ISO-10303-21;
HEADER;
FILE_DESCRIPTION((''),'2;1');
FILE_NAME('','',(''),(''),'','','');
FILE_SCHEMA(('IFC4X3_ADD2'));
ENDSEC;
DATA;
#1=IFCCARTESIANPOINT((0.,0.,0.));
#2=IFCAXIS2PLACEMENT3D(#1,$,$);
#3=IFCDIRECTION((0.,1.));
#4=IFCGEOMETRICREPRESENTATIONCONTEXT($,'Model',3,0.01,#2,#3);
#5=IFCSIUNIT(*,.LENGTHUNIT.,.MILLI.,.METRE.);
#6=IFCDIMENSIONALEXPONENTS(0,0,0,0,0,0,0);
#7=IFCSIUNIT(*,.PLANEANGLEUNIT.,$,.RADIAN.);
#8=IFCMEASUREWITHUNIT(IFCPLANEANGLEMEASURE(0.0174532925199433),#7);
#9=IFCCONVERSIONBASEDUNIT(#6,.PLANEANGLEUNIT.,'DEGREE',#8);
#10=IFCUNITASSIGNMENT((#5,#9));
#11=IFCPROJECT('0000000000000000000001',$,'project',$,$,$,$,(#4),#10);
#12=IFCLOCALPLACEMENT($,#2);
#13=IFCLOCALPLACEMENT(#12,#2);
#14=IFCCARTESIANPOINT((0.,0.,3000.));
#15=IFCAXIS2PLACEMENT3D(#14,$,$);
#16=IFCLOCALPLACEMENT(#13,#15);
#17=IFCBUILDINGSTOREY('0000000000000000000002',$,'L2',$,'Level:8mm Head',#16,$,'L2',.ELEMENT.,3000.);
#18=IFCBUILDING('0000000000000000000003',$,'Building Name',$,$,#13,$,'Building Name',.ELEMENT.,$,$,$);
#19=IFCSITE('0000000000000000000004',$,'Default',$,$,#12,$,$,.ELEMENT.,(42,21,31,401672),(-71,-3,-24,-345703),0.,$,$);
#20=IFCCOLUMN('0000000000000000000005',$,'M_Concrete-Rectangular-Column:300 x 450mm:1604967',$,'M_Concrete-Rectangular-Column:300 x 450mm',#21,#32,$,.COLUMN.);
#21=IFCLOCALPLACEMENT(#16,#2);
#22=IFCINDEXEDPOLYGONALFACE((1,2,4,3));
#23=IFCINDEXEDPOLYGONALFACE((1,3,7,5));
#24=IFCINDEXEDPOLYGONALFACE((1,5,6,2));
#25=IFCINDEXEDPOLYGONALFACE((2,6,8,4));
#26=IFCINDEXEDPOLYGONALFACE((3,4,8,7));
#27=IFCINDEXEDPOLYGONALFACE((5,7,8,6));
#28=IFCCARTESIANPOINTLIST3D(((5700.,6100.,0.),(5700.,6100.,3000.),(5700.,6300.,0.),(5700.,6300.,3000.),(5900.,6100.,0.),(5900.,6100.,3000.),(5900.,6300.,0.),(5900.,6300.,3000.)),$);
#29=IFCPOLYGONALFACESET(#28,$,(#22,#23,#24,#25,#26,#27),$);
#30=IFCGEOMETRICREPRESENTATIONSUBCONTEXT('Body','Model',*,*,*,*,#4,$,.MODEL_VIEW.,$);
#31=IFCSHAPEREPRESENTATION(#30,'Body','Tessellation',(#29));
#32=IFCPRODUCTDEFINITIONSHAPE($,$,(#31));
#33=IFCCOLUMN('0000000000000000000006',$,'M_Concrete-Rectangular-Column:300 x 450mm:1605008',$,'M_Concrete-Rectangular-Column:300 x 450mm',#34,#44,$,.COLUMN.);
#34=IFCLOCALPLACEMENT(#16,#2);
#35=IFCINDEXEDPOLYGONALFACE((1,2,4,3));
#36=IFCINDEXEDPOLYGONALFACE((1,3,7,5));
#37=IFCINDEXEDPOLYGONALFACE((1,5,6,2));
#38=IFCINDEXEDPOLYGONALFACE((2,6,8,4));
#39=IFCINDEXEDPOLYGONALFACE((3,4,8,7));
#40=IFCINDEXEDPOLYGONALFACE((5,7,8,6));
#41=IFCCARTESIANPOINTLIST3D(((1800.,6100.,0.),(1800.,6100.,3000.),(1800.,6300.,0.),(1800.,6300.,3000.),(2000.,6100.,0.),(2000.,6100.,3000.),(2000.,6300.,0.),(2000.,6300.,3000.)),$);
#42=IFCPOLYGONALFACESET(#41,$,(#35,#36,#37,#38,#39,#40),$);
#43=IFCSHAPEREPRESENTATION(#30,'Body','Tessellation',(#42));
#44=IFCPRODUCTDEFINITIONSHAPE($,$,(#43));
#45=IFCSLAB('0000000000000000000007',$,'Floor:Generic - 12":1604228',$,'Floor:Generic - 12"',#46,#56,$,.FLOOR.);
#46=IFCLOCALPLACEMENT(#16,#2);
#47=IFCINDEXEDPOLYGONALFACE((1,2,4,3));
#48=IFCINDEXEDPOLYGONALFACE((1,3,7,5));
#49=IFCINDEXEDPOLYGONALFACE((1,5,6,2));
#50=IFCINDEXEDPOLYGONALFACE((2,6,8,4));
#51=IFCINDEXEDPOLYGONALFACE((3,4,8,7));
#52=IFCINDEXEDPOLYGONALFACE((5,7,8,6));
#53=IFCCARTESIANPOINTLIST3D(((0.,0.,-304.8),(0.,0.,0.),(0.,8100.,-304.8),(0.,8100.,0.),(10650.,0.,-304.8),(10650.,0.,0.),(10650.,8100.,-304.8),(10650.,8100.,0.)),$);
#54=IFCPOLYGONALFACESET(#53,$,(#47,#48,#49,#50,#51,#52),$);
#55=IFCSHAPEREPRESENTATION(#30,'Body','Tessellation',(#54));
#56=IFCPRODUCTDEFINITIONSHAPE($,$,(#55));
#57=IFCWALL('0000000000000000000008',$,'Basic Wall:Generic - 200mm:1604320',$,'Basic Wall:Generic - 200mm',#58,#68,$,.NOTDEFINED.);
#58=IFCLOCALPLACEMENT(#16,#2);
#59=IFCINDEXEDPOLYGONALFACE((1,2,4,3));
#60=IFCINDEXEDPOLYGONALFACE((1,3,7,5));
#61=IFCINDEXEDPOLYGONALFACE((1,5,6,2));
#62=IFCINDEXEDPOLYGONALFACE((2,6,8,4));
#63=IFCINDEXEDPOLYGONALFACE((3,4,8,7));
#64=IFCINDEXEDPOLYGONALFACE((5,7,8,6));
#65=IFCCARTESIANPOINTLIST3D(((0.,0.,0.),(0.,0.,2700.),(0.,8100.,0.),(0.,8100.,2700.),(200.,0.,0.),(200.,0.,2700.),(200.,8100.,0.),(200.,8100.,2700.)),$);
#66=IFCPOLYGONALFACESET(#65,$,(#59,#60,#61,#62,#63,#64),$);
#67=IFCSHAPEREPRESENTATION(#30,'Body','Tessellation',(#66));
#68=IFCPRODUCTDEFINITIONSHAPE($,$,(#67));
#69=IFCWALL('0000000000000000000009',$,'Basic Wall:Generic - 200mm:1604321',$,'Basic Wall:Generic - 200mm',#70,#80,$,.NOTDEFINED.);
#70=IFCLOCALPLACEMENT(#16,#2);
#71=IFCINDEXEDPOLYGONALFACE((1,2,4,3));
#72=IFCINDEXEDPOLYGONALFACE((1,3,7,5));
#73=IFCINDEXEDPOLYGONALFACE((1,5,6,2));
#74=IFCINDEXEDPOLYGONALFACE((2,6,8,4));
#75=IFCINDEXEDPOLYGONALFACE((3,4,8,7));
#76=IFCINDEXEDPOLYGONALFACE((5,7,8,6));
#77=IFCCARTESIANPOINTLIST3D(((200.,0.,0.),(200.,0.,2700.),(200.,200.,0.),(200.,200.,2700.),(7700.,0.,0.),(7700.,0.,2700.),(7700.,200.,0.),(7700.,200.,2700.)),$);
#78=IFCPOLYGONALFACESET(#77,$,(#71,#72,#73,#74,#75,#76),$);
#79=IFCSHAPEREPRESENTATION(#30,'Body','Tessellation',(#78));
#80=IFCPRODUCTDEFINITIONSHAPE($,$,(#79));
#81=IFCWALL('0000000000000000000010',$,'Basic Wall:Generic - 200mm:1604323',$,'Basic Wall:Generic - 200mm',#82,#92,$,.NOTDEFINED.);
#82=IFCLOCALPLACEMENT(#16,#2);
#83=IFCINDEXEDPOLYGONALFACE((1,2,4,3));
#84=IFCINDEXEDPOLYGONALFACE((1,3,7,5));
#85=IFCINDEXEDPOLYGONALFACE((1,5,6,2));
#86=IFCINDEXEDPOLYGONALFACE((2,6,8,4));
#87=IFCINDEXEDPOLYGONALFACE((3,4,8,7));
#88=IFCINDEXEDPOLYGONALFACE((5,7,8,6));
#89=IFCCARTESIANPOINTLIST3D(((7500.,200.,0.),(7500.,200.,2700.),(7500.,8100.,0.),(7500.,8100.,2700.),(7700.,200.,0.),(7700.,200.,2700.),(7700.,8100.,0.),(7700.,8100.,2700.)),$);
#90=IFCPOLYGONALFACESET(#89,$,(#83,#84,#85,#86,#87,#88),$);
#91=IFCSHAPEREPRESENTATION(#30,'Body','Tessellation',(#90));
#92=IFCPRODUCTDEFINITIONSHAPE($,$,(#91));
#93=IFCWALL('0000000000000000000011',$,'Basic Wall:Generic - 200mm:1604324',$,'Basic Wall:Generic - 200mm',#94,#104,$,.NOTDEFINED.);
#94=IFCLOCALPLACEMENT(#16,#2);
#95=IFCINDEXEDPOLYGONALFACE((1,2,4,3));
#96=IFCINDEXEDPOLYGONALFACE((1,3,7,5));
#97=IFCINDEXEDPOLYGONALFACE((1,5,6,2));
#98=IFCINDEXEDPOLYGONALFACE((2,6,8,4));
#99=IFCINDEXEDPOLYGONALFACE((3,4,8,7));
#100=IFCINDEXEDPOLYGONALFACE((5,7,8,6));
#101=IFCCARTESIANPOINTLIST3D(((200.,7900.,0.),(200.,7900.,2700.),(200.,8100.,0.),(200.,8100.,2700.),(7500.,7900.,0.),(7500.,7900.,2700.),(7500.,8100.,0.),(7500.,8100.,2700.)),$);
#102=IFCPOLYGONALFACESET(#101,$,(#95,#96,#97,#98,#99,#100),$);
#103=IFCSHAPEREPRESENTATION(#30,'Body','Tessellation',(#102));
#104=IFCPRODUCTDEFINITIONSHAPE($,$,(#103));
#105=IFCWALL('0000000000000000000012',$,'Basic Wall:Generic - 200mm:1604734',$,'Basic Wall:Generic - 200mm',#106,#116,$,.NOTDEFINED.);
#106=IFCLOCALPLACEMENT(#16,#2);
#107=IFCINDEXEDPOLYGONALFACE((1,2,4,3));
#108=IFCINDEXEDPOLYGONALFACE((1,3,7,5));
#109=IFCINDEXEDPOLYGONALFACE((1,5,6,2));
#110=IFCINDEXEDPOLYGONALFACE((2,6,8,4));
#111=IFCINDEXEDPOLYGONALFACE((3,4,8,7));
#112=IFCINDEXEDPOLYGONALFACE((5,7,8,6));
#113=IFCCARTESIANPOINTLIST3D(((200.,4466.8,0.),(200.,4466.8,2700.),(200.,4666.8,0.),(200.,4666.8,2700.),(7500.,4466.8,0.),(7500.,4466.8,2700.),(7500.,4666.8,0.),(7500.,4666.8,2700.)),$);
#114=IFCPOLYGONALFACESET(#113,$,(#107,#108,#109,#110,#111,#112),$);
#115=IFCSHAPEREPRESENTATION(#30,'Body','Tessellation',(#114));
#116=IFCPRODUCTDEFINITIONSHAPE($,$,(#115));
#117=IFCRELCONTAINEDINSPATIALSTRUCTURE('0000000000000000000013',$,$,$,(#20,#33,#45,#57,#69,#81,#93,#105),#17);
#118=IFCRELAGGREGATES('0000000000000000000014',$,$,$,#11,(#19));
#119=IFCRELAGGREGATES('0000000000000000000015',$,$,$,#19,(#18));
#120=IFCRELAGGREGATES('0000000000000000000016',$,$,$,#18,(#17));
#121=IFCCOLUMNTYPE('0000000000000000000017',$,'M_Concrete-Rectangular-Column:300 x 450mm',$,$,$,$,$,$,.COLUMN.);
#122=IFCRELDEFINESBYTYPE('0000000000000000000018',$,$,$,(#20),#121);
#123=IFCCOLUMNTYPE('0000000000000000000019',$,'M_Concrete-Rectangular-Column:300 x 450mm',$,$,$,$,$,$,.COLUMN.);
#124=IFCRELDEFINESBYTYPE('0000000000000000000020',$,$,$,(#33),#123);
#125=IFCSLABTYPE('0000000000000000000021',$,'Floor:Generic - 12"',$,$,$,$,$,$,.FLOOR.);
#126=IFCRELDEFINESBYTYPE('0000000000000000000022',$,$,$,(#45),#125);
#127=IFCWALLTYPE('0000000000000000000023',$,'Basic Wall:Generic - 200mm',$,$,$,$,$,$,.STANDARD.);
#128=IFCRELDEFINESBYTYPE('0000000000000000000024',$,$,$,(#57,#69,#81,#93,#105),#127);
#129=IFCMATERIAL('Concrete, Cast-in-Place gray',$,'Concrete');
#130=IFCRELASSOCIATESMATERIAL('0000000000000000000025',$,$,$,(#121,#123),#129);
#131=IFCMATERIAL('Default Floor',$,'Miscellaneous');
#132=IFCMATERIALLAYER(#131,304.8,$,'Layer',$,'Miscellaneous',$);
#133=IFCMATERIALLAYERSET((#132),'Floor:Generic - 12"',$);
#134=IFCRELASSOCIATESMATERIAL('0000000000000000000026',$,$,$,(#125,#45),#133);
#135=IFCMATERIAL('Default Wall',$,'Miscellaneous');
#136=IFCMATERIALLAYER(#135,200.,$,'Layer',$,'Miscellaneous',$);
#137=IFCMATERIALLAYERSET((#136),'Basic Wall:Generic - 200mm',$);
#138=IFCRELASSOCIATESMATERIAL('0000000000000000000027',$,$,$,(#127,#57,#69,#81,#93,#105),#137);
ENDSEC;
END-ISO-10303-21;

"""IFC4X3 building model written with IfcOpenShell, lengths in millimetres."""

from ifc_helpers import new_model, entity, si_unit, converted_unit, direction, frame, frame_2d, origin, origin_2d_with_axis, place, context, subcontext, project, spatial, rectangle, extrude, source, transform, mapped, material, layer, layer_set, layer_usage, material_profile, profile_set, type_object, type_shapes, element, save


model = new_model("IFC4X3")

# Units and contexts
model_context = context("Model", 3, precision=0.01, world=origin(), true_north=direction((0.0, 1.0)))
body_context = subcontext(model_context, "Body", "Model", "MODEL_VIEW")
ifc_project = project(units=[si_unit("LENGTHUNIT", "METRE", prefix="MILLI"), converted_unit("PLANEANGLEUNIT", "DEGREE", entity("IfcPlaneAngleMeasure", 0.0174532925199433), si_unit("PLANEANGLEUNIT", "RADIAN"), dimensions=[0, 0, 0, 0, 0, 0, 0])], contexts=[model_context])

# Site, building, storey
site_placement = place(None, origin())
site = spatial("IfcSite", under=ifc_project, at=site_placement, Name="Default", CompositionType="ELEMENT", RefLatitude=(42, 21, 31, 401672), RefLongitude=(-71, -3, -24, -345703), RefElevation=0.0)
building_placement = place(site_placement, origin())
building = spatial("IfcBuilding", under=site, at=building_placement, Name="Building Name", LongName="Building Name", CompositionType="ELEMENT")
storey_placement = place(building_placement, frame((0.0, 0.0, 3000.0)))
storey = spatial("IfcBuildingStorey", under=building, at=storey_placement, Name="L2", ObjectType="Level:8mm Head", LongName="L2", CompositionType="ELEMENT", Elevation=3000.0)

# Columns
ifc_material_1 = material(Name="Concrete, Cast-in-Place gray", Category="Concrete")
ifc_material_profile = material_profile(ifc_material_1, rectangle(XDim=200.0, YDim=200.0, at=frame_2d((0.0, 0.0), x_axis=(1.0, 0.0))), Name="300 x 450mm")
ifc_profile_set = profile_set([ifc_material_profile], Name="300 x 450mm")
column_type_1 = type_object("IfcColumnType", Name="M_Concrete-Rectangular-Column:300 x 450mm", PredefinedType="COLUMN", material=ifc_profile_set)
shared_shape_1 = source(origin(), body_context, "Body", "SweptSolid", [
    extrude(rectangle(XDim=200.0, YDim=200.0, at=frame_2d((0.0, 0.0), x_axis=(1.0, 0.0))), frame((5800.0, 6200.0, 3000.0), z_axis=(0.0, 0.0, 1.0), x_axis=(-1.0, 0.0, 0.0)), (0.0, 0.0, 1.0), 3000.0),
])
type_shapes(column_type_1, [shared_shape_1])
column_1_placement = place(storey_placement, frame((0.0, 0.0, -3000.0)))
element("IfcColumn", 1, at=column_1_placement, inside=storey, type_object=column_type_1, Name="M_Concrete-Rectangular-Column:300 x 450mm:1604967", ObjectType="M_Concrete-Rectangular-Column:300 x 450mm", PredefinedType="COLUMN", context=body_context, shape_type="MappedRepresentation", body=[
    mapped(shared_shape_1, transform((0.0, 0.0, 0.0), scale=1.0)),
])
column_type_2 = type_object("IfcColumnType", Name="M_Concrete-Rectangular-Column:300 x 450mm", PredefinedType="COLUMN", material=ifc_profile_set)
shared_shape_2 = source(origin(), body_context, "Body", "SweptSolid", [
    extrude(rectangle(XDim=200.0, YDim=200.0, at=frame_2d((0.0, 0.0), x_axis=(1.0, 0.0))), frame((1900.0, 6200.0, 3000.0), z_axis=(0.0, 0.0, 1.0), x_axis=(-1.0, 0.0, 0.0)), (0.0, 0.0, 1.0), 3000.0),
])
type_shapes(column_type_2, [shared_shape_2])
column_2_placement = place(storey_placement, frame((0.0, 0.0, -3000.0)))
element("IfcColumn", 2, at=column_2_placement, inside=storey, type_object=column_type_2, Name="M_Concrete-Rectangular-Column:300 x 450mm:1605008", ObjectType="M_Concrete-Rectangular-Column:300 x 450mm", PredefinedType="COLUMN", context=body_context, shape_type="MappedRepresentation", body=[
    mapped(shared_shape_2, transform((0.0, 0.0, 0.0), scale=1.0)),
])

# Slab
ifc_material_2 = material(Name="Default Floor", Category="Miscellaneous")
ifc_layer_1 = layer(ifc_material_2, 304.8, Name="Layer", Category="Miscellaneous")
ifc_layer_set_1 = layer_set([ifc_layer_1], Name="Floor:Generic - 12\"")
ifc_layer_usage = layer_usage(ifc_layer_set_1, "AXIS3", "POSITIVE", 0.0)
slab_type = type_object("IfcSlabType", Name="Floor:Generic - 12\"", PredefinedType="FLOOR", material=ifc_layer_set_1)
slab_placement = place(storey_placement, origin())
element("IfcSlab", 3, at=slab_placement, inside=storey, type_object=slab_type, material=ifc_layer_usage, Name="Floor:Generic - 12\":1604228", ObjectType="Floor:Generic - 12\"", PredefinedType="FLOOR", context=body_context, shape_type="SweptSolid", body=[
    extrude(rectangle(XDim=8100.0, YDim=10650.0, at=origin_2d_with_axis()), frame((5325.0, 4050.0, 0.0), z_axis=(0.0, 0.0, -1.0), x_axis=(0.0, 1.0, 0.0)), (0.0, 0.0, 1.0), 304.8),
])

# Walls
ifc_material_3 = material(Name="Default Wall", Category="Miscellaneous")
ifc_layer_2 = layer(ifc_material_3, 200.0, Name="Layer", Category="Miscellaneous")
ifc_layer_set_2 = layer_set([ifc_layer_2], Name="Basic Wall:Generic - 200mm")
wall_type = type_object("IfcWallType", Name="Basic Wall:Generic - 200mm", PredefinedType="STANDARD", material=ifc_layer_set_2)
wall_1_placement = place(storey_placement, frame((100.0, 8100.0, 0.0), z_axis=(0.0, 0.0, 1.0), x_axis=(0.0, -1.0, 0.0)))
element("IfcWall", 4, at=wall_1_placement, inside=storey, type_object=wall_type, material=ifc_layer_set_2, Name="Basic Wall:Generic - 200mm:1604320", ObjectType="Basic Wall:Generic - 200mm", PredefinedType="NOTDEFINED", context=body_context, shape_type="SweptSolid", body=[
    extrude(rectangle(XDim=8100.0, YDim=200.0, at=frame_2d((4050.0, 0.0), x_axis=(-1.0, 0.0))), origin(), (0.0, 0.0, 1.0), 2700.0),
])
wall_2_placement = place(storey_placement, frame((200.0, 100.0, 0.0)))
element("IfcWall", 5, at=wall_2_placement, inside=storey, type_object=wall_type, material=ifc_layer_set_2, Name="Basic Wall:Generic - 200mm:1604321", ObjectType="Basic Wall:Generic - 200mm", PredefinedType="NOTDEFINED", context=body_context, shape_type="SweptSolid", body=[
    extrude(rectangle(XDim=7500.0, YDim=200.0, at=frame_2d((3750.0, 0.0), x_axis=(-1.0, 0.0))), origin(), (0.0, 0.0, 1.0), 2700.0),
])
wall_3_placement = place(storey_placement, frame((7600.0, 200.0, 0.0), z_axis=(0.0, 0.0, 1.0), x_axis=(0.0, 1.0, 0.0)))
element("IfcWall", 6, at=wall_3_placement, inside=storey, type_object=wall_type, material=ifc_layer_set_2, Name="Basic Wall:Generic - 200mm:1604323", ObjectType="Basic Wall:Generic - 200mm", PredefinedType="NOTDEFINED", context=body_context, shape_type="SweptSolid", body=[
    extrude(rectangle(XDim=7900.0, YDim=200.0, at=frame_2d((3950.0, 0.0), x_axis=(-1.0, 0.0))), origin(), (0.0, 0.0, 1.0), 2700.0),
])
wall_4_placement = place(storey_placement, frame((7500.0, 8000.0, 0.0), z_axis=(0.0, 0.0, 1.0), x_axis=(-1.0, 0.0, 0.0)))
element("IfcWall", 7, at=wall_4_placement, inside=storey, type_object=wall_type, material=ifc_layer_set_2, Name="Basic Wall:Generic - 200mm:1604324", ObjectType="Basic Wall:Generic - 200mm", PredefinedType="NOTDEFINED", context=body_context, shape_type="SweptSolid", body=[
    extrude(rectangle(XDim=7300.0, YDim=200.0, at=frame_2d((3650.0, 0.0), x_axis=(-1.0, 0.0))), origin(), (0.0, 0.0, 1.0), 2700.0),
])
wall_5_placement = place(storey_placement, frame((7500.0, 4566.8, 0.0), z_axis=(0.0, 0.0, 1.0), x_axis=(-1.0, 0.0, 0.0)))
element("IfcWall", 8, at=wall_5_placement, inside=storey, type_object=wall_type, material=ifc_layer_set_2, Name="Basic Wall:Generic - 200mm:1604734", ObjectType="Basic Wall:Generic - 200mm", PredefinedType="NOTDEFINED", context=body_context, shape_type="SweptSolid", body=[
    extrude(rectangle(XDim=7300.0, YDim=200.0, at=frame_2d((3650.0, 0.0), x_axis=(-1.0, 0.0))), origin(), (0.0, 0.0, 1.0), 2700.0),
])

save(model, "model.ifc")
